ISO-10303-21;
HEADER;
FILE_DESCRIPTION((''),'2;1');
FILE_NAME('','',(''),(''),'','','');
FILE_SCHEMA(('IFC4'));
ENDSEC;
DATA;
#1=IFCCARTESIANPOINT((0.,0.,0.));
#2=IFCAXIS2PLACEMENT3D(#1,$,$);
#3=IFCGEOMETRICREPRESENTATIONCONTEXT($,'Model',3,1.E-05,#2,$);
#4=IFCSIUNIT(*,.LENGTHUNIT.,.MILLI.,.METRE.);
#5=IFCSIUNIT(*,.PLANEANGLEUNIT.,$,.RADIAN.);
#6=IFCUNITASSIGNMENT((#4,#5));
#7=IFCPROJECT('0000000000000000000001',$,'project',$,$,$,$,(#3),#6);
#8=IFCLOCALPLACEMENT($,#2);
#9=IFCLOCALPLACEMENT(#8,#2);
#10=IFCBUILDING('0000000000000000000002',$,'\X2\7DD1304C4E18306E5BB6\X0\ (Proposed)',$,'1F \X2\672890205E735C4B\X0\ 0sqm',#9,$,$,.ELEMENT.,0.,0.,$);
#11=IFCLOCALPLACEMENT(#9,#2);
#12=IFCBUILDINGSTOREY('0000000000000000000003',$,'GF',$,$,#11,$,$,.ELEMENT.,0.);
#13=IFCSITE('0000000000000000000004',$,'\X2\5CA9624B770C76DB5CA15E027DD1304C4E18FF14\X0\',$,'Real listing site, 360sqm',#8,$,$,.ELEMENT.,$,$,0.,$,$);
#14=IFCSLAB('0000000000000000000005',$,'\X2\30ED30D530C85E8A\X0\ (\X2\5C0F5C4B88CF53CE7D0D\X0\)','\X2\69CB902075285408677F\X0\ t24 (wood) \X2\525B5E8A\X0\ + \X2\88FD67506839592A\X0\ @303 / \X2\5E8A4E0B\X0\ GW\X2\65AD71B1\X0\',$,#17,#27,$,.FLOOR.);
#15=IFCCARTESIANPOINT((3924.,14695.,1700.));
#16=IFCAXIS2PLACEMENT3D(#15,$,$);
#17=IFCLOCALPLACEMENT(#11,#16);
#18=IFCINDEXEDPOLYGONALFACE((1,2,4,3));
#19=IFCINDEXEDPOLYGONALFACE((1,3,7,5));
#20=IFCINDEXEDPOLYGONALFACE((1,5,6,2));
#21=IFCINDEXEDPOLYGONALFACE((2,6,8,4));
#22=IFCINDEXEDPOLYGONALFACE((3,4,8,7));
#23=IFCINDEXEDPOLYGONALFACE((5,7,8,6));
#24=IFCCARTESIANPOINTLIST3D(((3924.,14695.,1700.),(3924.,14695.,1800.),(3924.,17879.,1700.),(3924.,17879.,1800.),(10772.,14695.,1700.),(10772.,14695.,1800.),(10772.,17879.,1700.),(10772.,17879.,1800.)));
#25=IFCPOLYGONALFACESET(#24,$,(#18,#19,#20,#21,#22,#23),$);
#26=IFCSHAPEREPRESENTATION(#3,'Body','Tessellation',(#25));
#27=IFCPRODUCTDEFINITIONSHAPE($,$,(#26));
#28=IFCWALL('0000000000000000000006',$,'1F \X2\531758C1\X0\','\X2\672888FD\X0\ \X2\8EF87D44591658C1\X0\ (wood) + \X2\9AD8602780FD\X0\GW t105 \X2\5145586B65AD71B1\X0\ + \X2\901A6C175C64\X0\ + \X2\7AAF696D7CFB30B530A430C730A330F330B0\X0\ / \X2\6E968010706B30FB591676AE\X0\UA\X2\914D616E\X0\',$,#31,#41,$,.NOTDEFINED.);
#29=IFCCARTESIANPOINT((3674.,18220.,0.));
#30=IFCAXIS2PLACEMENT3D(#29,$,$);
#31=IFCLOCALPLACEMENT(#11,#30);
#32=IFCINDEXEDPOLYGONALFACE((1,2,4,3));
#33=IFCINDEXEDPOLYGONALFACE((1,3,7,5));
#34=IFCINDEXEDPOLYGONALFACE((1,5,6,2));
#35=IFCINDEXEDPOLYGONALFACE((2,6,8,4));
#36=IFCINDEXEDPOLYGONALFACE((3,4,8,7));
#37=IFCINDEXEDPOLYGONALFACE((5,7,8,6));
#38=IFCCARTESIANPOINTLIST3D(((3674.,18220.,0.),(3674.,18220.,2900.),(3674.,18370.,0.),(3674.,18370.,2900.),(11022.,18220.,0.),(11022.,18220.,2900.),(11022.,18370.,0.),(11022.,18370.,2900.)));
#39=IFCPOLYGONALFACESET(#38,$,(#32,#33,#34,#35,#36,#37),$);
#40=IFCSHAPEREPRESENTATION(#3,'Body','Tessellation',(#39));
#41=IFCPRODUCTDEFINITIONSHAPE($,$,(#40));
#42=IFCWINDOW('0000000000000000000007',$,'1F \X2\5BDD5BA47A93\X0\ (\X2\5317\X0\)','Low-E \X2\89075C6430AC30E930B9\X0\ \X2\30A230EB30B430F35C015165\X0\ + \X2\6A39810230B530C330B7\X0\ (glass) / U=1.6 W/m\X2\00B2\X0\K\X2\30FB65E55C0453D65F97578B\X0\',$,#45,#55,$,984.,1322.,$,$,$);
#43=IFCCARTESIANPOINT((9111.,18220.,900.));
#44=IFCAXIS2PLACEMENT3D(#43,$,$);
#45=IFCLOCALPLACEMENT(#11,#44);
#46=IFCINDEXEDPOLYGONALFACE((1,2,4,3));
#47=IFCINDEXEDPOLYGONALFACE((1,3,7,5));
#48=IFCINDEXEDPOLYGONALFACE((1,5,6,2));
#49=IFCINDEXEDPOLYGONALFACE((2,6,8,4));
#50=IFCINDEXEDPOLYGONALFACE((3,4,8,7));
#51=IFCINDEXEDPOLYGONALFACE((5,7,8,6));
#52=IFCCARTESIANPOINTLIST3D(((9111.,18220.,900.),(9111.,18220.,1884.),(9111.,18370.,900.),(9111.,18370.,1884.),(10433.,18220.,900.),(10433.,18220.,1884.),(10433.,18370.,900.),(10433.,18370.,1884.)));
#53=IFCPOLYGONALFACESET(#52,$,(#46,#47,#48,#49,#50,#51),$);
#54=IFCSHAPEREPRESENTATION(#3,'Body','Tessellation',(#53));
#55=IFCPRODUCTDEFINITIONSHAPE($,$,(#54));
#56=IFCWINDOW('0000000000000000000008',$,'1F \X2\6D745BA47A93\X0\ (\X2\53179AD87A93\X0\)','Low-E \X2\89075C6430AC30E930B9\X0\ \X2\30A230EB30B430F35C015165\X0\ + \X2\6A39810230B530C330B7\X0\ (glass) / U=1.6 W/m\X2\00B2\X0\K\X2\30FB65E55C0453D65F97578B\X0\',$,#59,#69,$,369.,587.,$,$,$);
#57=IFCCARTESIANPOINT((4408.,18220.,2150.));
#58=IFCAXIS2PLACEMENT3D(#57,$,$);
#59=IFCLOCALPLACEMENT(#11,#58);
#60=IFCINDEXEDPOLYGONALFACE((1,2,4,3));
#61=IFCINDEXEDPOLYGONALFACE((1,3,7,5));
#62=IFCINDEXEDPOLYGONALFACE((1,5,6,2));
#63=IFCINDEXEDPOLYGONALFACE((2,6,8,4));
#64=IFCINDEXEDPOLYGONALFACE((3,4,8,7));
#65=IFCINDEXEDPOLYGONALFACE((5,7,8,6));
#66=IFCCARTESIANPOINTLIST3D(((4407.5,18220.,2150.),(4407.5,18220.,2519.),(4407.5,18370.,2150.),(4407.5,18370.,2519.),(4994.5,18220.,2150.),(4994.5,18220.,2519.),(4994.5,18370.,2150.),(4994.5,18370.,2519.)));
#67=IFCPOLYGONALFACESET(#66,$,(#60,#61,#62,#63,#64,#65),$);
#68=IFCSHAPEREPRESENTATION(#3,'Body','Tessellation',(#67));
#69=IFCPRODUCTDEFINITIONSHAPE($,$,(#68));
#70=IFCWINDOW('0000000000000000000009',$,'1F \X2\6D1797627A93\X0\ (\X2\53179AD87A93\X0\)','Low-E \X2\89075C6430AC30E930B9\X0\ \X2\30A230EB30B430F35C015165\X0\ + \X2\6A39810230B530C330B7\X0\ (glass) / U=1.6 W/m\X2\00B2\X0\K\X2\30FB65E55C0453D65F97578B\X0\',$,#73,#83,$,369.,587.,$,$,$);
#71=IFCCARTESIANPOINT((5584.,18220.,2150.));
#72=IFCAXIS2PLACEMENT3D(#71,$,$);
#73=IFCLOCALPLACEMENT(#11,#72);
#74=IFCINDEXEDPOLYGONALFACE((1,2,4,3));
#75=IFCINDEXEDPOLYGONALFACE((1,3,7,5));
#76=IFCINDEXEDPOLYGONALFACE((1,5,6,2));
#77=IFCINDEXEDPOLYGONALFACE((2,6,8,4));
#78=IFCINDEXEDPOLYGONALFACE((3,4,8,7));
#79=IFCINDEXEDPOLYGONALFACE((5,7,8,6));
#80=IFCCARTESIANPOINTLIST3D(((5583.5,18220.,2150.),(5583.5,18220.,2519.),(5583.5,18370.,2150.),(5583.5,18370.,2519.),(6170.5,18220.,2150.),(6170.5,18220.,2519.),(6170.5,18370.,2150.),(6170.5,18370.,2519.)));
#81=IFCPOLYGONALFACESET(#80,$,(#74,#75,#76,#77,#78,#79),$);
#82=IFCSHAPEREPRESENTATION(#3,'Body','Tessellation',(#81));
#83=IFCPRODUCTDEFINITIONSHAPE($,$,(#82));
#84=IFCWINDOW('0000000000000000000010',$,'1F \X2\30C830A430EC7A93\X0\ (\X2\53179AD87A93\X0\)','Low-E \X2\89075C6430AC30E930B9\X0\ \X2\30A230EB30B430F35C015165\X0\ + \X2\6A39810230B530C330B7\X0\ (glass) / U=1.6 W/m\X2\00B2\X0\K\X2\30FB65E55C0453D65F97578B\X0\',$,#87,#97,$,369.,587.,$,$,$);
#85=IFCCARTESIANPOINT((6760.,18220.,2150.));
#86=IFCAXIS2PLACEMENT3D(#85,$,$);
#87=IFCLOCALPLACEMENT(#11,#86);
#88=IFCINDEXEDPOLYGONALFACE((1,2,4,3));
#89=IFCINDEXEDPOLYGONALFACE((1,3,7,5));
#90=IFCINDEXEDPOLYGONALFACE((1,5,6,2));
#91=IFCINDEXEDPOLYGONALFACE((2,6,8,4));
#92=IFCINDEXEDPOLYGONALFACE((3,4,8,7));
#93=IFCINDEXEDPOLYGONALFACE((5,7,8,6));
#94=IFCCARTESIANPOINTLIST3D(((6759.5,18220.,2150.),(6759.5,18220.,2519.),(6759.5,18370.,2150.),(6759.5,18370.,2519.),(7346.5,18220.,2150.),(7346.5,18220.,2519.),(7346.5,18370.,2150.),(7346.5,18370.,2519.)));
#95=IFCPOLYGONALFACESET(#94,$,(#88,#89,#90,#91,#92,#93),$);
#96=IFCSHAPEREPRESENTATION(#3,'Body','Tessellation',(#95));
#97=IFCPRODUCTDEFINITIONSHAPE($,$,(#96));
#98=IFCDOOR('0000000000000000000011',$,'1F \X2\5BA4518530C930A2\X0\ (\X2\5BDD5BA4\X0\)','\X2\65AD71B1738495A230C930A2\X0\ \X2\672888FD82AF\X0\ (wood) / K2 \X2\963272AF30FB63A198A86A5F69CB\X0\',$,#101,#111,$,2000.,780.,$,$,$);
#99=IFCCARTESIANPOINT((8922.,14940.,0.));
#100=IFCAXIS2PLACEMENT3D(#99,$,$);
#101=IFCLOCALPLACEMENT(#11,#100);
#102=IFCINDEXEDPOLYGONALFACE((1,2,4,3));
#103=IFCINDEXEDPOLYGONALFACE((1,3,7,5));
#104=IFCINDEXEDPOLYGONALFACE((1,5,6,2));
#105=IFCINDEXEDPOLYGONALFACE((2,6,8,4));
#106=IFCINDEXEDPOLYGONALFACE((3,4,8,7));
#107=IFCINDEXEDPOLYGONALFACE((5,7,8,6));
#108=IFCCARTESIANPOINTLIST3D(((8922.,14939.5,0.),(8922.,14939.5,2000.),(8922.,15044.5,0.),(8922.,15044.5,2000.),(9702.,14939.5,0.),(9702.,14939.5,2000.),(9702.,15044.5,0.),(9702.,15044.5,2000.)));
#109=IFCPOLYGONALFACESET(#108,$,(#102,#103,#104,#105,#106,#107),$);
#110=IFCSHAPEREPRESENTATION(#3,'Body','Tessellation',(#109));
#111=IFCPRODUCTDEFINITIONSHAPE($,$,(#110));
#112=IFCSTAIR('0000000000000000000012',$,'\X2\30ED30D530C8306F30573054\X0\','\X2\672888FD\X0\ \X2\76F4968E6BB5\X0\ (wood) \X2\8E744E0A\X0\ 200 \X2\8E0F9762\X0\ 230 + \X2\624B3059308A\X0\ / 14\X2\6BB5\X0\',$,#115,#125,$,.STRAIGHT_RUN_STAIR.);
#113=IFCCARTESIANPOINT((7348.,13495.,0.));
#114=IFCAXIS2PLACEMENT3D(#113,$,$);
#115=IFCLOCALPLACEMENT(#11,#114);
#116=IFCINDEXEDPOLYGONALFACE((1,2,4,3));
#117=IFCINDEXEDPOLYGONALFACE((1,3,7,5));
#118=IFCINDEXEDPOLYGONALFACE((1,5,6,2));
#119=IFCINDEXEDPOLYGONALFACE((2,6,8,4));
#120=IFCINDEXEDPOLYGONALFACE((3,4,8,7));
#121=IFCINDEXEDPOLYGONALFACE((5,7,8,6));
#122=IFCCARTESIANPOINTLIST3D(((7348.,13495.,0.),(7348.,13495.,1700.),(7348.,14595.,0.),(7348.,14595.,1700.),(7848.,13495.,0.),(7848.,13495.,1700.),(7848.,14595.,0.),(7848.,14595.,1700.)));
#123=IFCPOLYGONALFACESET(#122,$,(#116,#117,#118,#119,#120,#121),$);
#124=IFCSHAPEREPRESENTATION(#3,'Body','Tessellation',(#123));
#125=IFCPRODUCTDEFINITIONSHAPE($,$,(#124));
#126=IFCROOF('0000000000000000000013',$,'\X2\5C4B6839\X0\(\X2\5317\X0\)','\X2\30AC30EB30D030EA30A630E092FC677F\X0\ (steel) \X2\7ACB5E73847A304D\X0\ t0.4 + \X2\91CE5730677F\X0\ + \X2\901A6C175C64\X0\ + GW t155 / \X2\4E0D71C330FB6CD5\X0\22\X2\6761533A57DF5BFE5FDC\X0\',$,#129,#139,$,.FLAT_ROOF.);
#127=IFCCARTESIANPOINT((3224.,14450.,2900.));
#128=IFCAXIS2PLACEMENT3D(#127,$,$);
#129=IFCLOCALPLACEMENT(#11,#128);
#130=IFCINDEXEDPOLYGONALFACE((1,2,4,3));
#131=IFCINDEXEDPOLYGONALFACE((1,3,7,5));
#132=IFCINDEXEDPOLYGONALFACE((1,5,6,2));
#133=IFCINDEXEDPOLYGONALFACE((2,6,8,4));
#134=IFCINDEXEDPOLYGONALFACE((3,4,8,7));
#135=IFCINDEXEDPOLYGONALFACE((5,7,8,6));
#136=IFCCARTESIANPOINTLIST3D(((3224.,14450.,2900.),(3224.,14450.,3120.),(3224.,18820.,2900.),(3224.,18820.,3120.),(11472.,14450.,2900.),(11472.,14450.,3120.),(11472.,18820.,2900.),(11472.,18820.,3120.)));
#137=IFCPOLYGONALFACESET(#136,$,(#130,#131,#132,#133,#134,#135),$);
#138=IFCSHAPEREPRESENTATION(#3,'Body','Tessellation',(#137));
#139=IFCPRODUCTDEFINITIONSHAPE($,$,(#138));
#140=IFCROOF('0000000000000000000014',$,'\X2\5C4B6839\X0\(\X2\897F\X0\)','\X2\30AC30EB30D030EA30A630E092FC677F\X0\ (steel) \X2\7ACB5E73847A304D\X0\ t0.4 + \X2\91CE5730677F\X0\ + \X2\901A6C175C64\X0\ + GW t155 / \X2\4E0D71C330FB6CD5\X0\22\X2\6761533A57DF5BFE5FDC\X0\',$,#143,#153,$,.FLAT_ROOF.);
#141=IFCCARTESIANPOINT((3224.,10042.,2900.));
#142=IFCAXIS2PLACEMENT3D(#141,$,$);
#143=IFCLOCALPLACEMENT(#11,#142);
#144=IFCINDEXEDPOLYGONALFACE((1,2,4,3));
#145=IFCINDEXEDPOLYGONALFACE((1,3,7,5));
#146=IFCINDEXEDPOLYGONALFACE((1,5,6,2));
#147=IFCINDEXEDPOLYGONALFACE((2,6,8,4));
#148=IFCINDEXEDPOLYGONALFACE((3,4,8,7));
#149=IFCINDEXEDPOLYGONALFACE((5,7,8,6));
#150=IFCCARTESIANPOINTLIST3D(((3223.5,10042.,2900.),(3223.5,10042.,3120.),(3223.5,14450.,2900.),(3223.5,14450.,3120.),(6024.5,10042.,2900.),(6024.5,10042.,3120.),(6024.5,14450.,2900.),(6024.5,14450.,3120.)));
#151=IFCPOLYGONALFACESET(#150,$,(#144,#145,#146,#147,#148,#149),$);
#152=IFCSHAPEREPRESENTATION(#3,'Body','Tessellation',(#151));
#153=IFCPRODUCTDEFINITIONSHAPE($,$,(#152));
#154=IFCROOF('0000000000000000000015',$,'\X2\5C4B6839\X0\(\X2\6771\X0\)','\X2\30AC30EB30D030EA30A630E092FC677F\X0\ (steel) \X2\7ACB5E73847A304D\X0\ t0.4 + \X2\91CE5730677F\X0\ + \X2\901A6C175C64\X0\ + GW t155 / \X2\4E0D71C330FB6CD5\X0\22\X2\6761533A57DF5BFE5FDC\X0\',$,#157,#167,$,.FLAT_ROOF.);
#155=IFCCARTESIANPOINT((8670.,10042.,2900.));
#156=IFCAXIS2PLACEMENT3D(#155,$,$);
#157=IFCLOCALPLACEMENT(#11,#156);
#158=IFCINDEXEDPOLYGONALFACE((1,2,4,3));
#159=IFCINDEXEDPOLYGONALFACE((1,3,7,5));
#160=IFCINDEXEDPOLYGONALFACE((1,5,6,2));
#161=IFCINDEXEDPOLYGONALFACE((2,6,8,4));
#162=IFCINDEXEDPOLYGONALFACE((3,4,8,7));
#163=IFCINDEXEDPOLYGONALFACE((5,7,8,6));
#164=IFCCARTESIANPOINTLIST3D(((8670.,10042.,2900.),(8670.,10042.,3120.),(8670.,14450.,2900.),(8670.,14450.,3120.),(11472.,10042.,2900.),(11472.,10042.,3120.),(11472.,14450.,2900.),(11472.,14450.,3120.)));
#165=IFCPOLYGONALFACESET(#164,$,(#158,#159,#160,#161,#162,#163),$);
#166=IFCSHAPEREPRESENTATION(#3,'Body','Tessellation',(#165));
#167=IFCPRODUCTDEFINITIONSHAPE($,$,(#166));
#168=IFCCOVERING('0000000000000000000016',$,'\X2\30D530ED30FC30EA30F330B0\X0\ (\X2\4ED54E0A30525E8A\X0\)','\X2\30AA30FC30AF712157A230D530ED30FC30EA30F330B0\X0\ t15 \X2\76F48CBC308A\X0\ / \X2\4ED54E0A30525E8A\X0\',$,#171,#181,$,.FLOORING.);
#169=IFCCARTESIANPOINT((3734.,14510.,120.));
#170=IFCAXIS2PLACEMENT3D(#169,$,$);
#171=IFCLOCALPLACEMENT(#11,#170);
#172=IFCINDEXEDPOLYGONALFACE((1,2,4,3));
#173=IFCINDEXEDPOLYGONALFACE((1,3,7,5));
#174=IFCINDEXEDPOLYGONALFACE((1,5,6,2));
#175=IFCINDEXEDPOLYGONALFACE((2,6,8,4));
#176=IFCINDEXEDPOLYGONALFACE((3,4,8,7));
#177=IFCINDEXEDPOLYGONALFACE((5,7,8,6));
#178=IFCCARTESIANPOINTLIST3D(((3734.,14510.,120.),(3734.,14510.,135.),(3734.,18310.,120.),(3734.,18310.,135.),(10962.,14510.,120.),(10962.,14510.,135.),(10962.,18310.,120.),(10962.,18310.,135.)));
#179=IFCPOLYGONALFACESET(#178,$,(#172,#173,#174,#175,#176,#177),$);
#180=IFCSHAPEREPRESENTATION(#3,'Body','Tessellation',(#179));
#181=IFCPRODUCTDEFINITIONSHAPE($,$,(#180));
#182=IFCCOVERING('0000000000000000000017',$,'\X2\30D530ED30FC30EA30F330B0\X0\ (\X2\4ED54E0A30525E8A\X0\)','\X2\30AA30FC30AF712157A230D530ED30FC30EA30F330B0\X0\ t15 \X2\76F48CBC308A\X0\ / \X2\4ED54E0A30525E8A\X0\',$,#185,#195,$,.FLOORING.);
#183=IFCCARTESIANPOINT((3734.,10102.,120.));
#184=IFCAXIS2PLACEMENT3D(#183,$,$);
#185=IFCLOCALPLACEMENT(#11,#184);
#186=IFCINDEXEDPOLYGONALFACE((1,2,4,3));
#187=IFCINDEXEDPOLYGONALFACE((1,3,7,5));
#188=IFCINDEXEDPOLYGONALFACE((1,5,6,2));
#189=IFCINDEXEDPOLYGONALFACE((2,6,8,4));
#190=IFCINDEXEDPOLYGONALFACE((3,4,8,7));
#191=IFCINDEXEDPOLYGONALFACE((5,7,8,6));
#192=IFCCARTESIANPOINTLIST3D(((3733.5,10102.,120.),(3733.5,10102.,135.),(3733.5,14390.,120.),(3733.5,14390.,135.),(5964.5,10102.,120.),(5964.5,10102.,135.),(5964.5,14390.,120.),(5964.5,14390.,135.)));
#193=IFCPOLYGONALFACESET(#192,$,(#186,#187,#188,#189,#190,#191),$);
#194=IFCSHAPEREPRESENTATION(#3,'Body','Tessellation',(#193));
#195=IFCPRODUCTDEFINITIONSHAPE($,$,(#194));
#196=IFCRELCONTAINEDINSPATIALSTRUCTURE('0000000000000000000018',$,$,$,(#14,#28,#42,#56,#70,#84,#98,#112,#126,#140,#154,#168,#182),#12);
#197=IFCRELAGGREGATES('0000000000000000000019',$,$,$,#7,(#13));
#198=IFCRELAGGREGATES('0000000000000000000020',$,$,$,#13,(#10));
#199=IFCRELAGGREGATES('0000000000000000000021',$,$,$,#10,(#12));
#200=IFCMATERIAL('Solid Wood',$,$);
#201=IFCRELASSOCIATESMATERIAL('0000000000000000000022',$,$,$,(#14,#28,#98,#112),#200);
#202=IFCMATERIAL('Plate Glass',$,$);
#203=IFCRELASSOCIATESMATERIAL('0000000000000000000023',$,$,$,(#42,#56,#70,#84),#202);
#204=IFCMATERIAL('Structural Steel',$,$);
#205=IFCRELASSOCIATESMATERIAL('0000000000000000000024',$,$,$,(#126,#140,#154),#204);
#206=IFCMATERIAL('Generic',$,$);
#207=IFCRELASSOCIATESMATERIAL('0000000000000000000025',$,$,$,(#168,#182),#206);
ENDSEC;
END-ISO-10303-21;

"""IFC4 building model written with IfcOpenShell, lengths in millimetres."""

from ifc_helpers import new_model, si_unit, frame, frame_2d, origin, place, context, project, spatial, rectangle, extrude, material, element, fill, save


model = new_model("IFC4")

# Units and contexts
model_context = context("Model", 3, precision=1e-05, world=origin())
ifc_project = project(units=[si_unit("LENGTHUNIT", "METRE", prefix="MILLI"), si_unit("PLANEANGLEUNIT", "RADIAN")], contexts=[model_context])

# Site, building, storey
site_placement = place(None, origin())
site = spatial("IfcSite", under=ifc_project, at=site_placement, Name="岩手県盛岡市緑が丘４", ObjectType="Real listing site, 360sqm", CompositionType="ELEMENT", RefElevation=0.0)
building_placement = place(site_placement, origin())
building = spatial("IfcBuilding", under=site, at=building_placement, Name="緑が丘の家 (Proposed)", ObjectType="1F 木造平屋 0sqm", CompositionType="ELEMENT", ElevationOfRefHeight=0.0, ElevationOfTerrain=0.0)
storey_placement = place(building_placement, origin())
storey = spatial("IfcBuildingStorey", under=building, at=storey_placement, Name="GF", CompositionType="ELEMENT", Elevation=0.0)

# Slab
ifc_material_1 = material(Name="Solid Wood")
slab_1_placement = place(storey_placement, frame((3924.0, 14695.0, 1700.0)))
element("IfcSlab", 1, at=slab_1_placement, inside=storey, material=ifc_material_1, Name="ロフト床 (小屋裏収納)", Description="構造用合板 t24 (wood) 剛床 + 製材根太 @303 / 床下 GW断熱", PredefinedType="FLOOR", context=model_context, shape_type="SweptSolid", body=[
    extrude(rectangle(XDim=6848.0, YDim=3184.0, at=frame_2d((3424.0, 1592.0))), frame((3924.0, 14695.0, 1700.0)), (0.0, 0.0, 1.0), 100.0),
])

# Wall, openings, windows
wall_1_placement = place(storey_placement, frame((3674.0, 18220.0, 0.0)))
wall_1 = element("IfcWall", 2, at=wall_1_placement, inside=storey, material=ifc_material_1, Name="1F 北壁", Description="木製 軸組外壁 (wood) + 高性能GW t105 充填断熱 + 通気層 + 窯業系サイディング / 準耐火・外皮UA配慮", PredefinedType="NOTDEFINED", context=model_context, shape_type="SweptSolid", body=[
    extrude(rectangle(XDim=7348.0, YDim=150.0, at=frame_2d((3674.0, 75.0))), frame((3674.0, 18220.0, 0.0)), (0.0, 0.0, 1.0), 2900.0),
])
opening_1_placement = place(storey_placement, frame((9111.0, 18220.0, 900.0)))
opening_1 = element("IfcOpeningElement", 3, at=opening_1_placement, cuts=wall_1, PredefinedType="NOTDEFINED", context=model_context, shape_type="SweptSolid", body=[
    extrude(rectangle(XDim=1322.0, YDim=150.0, at=frame_2d((661.0, 75.0))), frame((9111.0, 18220.0, 900.0)), (0.0, 0.0, 1.0), 984.0),
])
opening_2_placement = place(storey_placement, frame((4408.0, 18220.0, 2150.0)))
opening_2 = element("IfcOpeningElement", 4, at=opening_2_placement, cuts=wall_1, PredefinedType="NOTDEFINED", context=model_context, shape_type="SweptSolid", body=[
    extrude(rectangle(XDim=587.0, YDim=150.0, at=frame_2d((293.0, 75.0))), frame((4408.0, 18220.0, 2150.0)), (0.0, 0.0, 1.0), 369.0),
])
opening_3_placement = place(storey_placement, frame((5584.0, 18220.0, 2150.0)))
opening_3 = element("IfcOpeningElement", 5, at=opening_3_placement, cuts=wall_1, PredefinedType="NOTDEFINED", context=model_context, shape_type="SweptSolid", body=[
    extrude(rectangle(XDim=587.0, YDim=150.0, at=frame_2d((293.0, 75.0))), frame((5584.0, 18220.0, 2150.0)), (0.0, 0.0, 1.0), 369.0),
])
opening_4_placement = place(storey_placement, frame((6760.0, 18220.0, 2150.0)))
opening_4 = element("IfcOpeningElement", 6, at=opening_4_placement, cuts=wall_1, PredefinedType="NOTDEFINED", context=model_context, shape_type="SweptSolid", body=[
    extrude(rectangle(XDim=587.0, YDim=150.0, at=frame_2d((293.0, 75.0))), frame((6760.0, 18220.0, 2150.0)), (0.0, 0.0, 1.0), 369.0),
])
ifc_material_2 = material(Name="Plate Glass")
window_1_placement = place(storey_placement, frame((9111.0, 18220.0, 900.0)))
window_1 = element("IfcWindow", 7, at=window_1_placement, inside=storey, material=ifc_material_2, Name="1F 寝室窓 (北)", Description="Low-E 複層ガラス アルゴン封入 + 樹脂サッシ (glass) / U=1.6 W/m²K・日射取得型", OverallHeight=984.0, OverallWidth=1322.0, context=model_context, shape_type="SweptSolid", body=[
    extrude(rectangle(XDim=1322.0, YDim=150.0, at=frame_2d((661.0, 75.0))), frame((9111.0, 18220.0, 900.0)), (0.0, 0.0, 1.0), 984.0),
])
fill(opening_1, window_1)
window_2_placement = place(storey_placement, frame((4408.0, 18220.0, 2150.0)))
window_2 = element("IfcWindow", 8, at=window_2_placement, inside=storey, material=ifc_material_2, Name="1F 浴室窓 (北高窓)", Description="Low-E 複層ガラス アルゴン封入 + 樹脂サッシ (glass) / U=1.6 W/m²K・日射取得型", OverallHeight=369.0, OverallWidth=587.0, context=model_context, shape_type="SweptSolid", body=[
    extrude(rectangle(XDim=587.0, YDim=150.0, at=frame_2d((293.0, 75.0))), frame((4408.0, 18220.0, 2150.0)), (0.0, 0.0, 1.0), 369.0),
])
fill(opening_2, window_2)
window_3_placement = place(storey_placement, frame((5584.0, 18220.0, 2150.0)))
window_3 = element("IfcWindow", 9, at=window_3_placement, inside=storey, material=ifc_material_2, Name="1F 洗面窓 (北高窓)", Description="Low-E 複層ガラス アルゴン封入 + 樹脂サッシ (glass) / U=1.6 W/m²K・日射取得型", OverallHeight=369.0, OverallWidth=587.0, context=model_context, shape_type="SweptSolid", body=[
    extrude(rectangle(XDim=587.0, YDim=150.0, at=frame_2d((293.0, 75.0))), frame((5584.0, 18220.0, 2150.0)), (0.0, 0.0, 1.0), 369.0),
])
fill(opening_3, window_3)
window_4_placement = place(storey_placement, frame((6760.0, 18220.0, 2150.0)))
window_4 = element("IfcWindow", 10, at=window_4_placement, inside=storey, material=ifc_material_2, Name="1F トイレ窓 (北高窓)", Description="Low-E 複層ガラス アルゴン封入 + 樹脂サッシ (glass) / U=1.6 W/m²K・日射取得型", OverallHeight=369.0, OverallWidth=587.0, context=model_context, shape_type="SweptSolid", body=[
    extrude(rectangle(XDim=587.0, YDim=150.0, at=frame_2d((293.0, 75.0))), frame((6760.0, 18220.0, 2150.0)), (0.0, 0.0, 1.0), 369.0),
])
fill(opening_4, window_4)

# Door
door_1_placement = place(storey_placement, frame((8922.0, 14940.0, 0.0)))
element("IfcDoor", 11, at=door_1_placement, inside=storey, material=ifc_material_1, Name="1F 室内ドア (寝室)", Description="断熱玄関ドア 木製芯 (wood) / K2 防犯・採風機構", OverallHeight=2000.0, OverallWidth=780.0, context=model_context, shape_type="SweptSolid", body=[
    extrude(rectangle(XDim=780.0, YDim=105.0, at=frame_2d((390.0, 52.0))), frame((8922.0, 14940.0, 0.0)), (0.0, 0.0, 1.0), 2000.0),
])

# Stair
stair_placement = place(storey_placement, frame((7348.0, 13495.0, 0.0)))
element("IfcStair", 12, at=stair_placement, inside=storey, material=ifc_material_1, Name="ロフトはしご", Description="木製 直階段 (wood) 蹴上 200 踏面 230 + 手すり / 14段", PredefinedType="STRAIGHT_RUN_STAIR", context=model_context, shape_type="SweptSolid", body=[
    extrude(rectangle(XDim=500.0, YDim=1100.0, at=frame_2d((250.0, 550.0))), frame((7348.0, 13495.0, 0.0)), (0.0, 0.0, 1.0), 1700.0),
])

# Roofs
ifc_material_3 = material(Name="Structural Steel")
roof_1_placement = place(storey_placement, frame((3224.0, 14450.0, 2900.0)))
element("IfcRoof", 13, at=roof_1_placement, inside=storey, material=ifc_material_3, Name="屋根(北)", Description="ガルバリウム鋼板 (steel) 立平葺き t0.4 + 野地板 + 通気層 + GW t155 / 不燃・法22条区域対応", PredefinedType="FLAT_ROOF", context=model_context, shape_type="SweptSolid", body=[
    extrude(rectangle(XDim=8248.0, YDim=4370.0, at=frame_2d((4124.0, 2185.0))), frame((3224.0, 14450.0, 2900.0)), (0.0, 0.0, 1.0), 220.0),
])
roof_2_placement = place(storey_placement, frame((3224.0, 10042.0, 2900.0)))
element("IfcRoof", 14, at=roof_2_placement, inside=storey, material=ifc_material_3, Name="屋根(西)", Description="ガルバリウム鋼板 (steel) 立平葺き t0.4 + 野地板 + 通気層 + GW t155 / 不燃・法22条区域対応", PredefinedType="FLAT_ROOF", context=model_context, shape_type="SweptSolid", body=[
    extrude(rectangle(XDim=2801.0, YDim=4408.0, at=frame_2d((1400.0, 2204.0))), frame((3224.0, 10042.0, 2900.0)), (0.0, 0.0, 1.0), 220.0),
])
roof_3_placement = place(storey_placement, frame((8670.0, 10042.0, 2900.0)))
element("IfcRoof", 15, at=roof_3_placement, inside=storey, material=ifc_material_3, Name="屋根(東)", Description="ガルバリウム鋼板 (steel) 立平葺き t0.4 + 野地板 + 通気層 + GW t155 / 不燃・法22条区域対応", PredefinedType="FLAT_ROOF", context=model_context, shape_type="SweptSolid", body=[
    extrude(rectangle(XDim=2802.0, YDim=4408.0, at=frame_2d((1401.0, 2204.0))), frame((8670.0, 10042.0, 2900.0)), (0.0, 0.0, 1.0), 220.0),
])

# Coverings
ifc_material_4 = material(Name="Generic")
covering_1_placement = place(storey_placement, frame((3734.0, 14510.0, 120.0)))
element("IfcCovering", 16, at=covering_1_placement, inside=storey, material=ifc_material_4, Name="フローリング (仕上げ床)", Description="オーク無垢フローリング t15 直貼り / 仕上げ床", PredefinedType="FLOORING", context=model_context, shape_type="SweptSolid", body=[
    extrude(rectangle(XDim=7228.0, YDim=3800.0, at=frame_2d((3614.0, 1900.0))), frame((3734.0, 14510.0, 120.0)), (0.0, 0.0, 1.0), 15.0),
])
covering_2_placement = place(storey_placement, frame((3734.0, 10102.0, 120.0)))
element("IfcCovering", 17, at=covering_2_placement, inside=storey, material=ifc_material_4, Name="フローリング (仕上げ床)", Description="オーク無垢フローリング t15 直貼り / 仕上げ床", PredefinedType="FLOORING", context=model_context, shape_type="SweptSolid", body=[
    extrude(rectangle(XDim=2231.0, YDim=4288.0, at=frame_2d((1115.0, 2144.0))), frame((3734.0, 10102.0, 120.0)), (0.0, 0.0, 1.0), 15.0),
])

save(model, "model.ifc")
